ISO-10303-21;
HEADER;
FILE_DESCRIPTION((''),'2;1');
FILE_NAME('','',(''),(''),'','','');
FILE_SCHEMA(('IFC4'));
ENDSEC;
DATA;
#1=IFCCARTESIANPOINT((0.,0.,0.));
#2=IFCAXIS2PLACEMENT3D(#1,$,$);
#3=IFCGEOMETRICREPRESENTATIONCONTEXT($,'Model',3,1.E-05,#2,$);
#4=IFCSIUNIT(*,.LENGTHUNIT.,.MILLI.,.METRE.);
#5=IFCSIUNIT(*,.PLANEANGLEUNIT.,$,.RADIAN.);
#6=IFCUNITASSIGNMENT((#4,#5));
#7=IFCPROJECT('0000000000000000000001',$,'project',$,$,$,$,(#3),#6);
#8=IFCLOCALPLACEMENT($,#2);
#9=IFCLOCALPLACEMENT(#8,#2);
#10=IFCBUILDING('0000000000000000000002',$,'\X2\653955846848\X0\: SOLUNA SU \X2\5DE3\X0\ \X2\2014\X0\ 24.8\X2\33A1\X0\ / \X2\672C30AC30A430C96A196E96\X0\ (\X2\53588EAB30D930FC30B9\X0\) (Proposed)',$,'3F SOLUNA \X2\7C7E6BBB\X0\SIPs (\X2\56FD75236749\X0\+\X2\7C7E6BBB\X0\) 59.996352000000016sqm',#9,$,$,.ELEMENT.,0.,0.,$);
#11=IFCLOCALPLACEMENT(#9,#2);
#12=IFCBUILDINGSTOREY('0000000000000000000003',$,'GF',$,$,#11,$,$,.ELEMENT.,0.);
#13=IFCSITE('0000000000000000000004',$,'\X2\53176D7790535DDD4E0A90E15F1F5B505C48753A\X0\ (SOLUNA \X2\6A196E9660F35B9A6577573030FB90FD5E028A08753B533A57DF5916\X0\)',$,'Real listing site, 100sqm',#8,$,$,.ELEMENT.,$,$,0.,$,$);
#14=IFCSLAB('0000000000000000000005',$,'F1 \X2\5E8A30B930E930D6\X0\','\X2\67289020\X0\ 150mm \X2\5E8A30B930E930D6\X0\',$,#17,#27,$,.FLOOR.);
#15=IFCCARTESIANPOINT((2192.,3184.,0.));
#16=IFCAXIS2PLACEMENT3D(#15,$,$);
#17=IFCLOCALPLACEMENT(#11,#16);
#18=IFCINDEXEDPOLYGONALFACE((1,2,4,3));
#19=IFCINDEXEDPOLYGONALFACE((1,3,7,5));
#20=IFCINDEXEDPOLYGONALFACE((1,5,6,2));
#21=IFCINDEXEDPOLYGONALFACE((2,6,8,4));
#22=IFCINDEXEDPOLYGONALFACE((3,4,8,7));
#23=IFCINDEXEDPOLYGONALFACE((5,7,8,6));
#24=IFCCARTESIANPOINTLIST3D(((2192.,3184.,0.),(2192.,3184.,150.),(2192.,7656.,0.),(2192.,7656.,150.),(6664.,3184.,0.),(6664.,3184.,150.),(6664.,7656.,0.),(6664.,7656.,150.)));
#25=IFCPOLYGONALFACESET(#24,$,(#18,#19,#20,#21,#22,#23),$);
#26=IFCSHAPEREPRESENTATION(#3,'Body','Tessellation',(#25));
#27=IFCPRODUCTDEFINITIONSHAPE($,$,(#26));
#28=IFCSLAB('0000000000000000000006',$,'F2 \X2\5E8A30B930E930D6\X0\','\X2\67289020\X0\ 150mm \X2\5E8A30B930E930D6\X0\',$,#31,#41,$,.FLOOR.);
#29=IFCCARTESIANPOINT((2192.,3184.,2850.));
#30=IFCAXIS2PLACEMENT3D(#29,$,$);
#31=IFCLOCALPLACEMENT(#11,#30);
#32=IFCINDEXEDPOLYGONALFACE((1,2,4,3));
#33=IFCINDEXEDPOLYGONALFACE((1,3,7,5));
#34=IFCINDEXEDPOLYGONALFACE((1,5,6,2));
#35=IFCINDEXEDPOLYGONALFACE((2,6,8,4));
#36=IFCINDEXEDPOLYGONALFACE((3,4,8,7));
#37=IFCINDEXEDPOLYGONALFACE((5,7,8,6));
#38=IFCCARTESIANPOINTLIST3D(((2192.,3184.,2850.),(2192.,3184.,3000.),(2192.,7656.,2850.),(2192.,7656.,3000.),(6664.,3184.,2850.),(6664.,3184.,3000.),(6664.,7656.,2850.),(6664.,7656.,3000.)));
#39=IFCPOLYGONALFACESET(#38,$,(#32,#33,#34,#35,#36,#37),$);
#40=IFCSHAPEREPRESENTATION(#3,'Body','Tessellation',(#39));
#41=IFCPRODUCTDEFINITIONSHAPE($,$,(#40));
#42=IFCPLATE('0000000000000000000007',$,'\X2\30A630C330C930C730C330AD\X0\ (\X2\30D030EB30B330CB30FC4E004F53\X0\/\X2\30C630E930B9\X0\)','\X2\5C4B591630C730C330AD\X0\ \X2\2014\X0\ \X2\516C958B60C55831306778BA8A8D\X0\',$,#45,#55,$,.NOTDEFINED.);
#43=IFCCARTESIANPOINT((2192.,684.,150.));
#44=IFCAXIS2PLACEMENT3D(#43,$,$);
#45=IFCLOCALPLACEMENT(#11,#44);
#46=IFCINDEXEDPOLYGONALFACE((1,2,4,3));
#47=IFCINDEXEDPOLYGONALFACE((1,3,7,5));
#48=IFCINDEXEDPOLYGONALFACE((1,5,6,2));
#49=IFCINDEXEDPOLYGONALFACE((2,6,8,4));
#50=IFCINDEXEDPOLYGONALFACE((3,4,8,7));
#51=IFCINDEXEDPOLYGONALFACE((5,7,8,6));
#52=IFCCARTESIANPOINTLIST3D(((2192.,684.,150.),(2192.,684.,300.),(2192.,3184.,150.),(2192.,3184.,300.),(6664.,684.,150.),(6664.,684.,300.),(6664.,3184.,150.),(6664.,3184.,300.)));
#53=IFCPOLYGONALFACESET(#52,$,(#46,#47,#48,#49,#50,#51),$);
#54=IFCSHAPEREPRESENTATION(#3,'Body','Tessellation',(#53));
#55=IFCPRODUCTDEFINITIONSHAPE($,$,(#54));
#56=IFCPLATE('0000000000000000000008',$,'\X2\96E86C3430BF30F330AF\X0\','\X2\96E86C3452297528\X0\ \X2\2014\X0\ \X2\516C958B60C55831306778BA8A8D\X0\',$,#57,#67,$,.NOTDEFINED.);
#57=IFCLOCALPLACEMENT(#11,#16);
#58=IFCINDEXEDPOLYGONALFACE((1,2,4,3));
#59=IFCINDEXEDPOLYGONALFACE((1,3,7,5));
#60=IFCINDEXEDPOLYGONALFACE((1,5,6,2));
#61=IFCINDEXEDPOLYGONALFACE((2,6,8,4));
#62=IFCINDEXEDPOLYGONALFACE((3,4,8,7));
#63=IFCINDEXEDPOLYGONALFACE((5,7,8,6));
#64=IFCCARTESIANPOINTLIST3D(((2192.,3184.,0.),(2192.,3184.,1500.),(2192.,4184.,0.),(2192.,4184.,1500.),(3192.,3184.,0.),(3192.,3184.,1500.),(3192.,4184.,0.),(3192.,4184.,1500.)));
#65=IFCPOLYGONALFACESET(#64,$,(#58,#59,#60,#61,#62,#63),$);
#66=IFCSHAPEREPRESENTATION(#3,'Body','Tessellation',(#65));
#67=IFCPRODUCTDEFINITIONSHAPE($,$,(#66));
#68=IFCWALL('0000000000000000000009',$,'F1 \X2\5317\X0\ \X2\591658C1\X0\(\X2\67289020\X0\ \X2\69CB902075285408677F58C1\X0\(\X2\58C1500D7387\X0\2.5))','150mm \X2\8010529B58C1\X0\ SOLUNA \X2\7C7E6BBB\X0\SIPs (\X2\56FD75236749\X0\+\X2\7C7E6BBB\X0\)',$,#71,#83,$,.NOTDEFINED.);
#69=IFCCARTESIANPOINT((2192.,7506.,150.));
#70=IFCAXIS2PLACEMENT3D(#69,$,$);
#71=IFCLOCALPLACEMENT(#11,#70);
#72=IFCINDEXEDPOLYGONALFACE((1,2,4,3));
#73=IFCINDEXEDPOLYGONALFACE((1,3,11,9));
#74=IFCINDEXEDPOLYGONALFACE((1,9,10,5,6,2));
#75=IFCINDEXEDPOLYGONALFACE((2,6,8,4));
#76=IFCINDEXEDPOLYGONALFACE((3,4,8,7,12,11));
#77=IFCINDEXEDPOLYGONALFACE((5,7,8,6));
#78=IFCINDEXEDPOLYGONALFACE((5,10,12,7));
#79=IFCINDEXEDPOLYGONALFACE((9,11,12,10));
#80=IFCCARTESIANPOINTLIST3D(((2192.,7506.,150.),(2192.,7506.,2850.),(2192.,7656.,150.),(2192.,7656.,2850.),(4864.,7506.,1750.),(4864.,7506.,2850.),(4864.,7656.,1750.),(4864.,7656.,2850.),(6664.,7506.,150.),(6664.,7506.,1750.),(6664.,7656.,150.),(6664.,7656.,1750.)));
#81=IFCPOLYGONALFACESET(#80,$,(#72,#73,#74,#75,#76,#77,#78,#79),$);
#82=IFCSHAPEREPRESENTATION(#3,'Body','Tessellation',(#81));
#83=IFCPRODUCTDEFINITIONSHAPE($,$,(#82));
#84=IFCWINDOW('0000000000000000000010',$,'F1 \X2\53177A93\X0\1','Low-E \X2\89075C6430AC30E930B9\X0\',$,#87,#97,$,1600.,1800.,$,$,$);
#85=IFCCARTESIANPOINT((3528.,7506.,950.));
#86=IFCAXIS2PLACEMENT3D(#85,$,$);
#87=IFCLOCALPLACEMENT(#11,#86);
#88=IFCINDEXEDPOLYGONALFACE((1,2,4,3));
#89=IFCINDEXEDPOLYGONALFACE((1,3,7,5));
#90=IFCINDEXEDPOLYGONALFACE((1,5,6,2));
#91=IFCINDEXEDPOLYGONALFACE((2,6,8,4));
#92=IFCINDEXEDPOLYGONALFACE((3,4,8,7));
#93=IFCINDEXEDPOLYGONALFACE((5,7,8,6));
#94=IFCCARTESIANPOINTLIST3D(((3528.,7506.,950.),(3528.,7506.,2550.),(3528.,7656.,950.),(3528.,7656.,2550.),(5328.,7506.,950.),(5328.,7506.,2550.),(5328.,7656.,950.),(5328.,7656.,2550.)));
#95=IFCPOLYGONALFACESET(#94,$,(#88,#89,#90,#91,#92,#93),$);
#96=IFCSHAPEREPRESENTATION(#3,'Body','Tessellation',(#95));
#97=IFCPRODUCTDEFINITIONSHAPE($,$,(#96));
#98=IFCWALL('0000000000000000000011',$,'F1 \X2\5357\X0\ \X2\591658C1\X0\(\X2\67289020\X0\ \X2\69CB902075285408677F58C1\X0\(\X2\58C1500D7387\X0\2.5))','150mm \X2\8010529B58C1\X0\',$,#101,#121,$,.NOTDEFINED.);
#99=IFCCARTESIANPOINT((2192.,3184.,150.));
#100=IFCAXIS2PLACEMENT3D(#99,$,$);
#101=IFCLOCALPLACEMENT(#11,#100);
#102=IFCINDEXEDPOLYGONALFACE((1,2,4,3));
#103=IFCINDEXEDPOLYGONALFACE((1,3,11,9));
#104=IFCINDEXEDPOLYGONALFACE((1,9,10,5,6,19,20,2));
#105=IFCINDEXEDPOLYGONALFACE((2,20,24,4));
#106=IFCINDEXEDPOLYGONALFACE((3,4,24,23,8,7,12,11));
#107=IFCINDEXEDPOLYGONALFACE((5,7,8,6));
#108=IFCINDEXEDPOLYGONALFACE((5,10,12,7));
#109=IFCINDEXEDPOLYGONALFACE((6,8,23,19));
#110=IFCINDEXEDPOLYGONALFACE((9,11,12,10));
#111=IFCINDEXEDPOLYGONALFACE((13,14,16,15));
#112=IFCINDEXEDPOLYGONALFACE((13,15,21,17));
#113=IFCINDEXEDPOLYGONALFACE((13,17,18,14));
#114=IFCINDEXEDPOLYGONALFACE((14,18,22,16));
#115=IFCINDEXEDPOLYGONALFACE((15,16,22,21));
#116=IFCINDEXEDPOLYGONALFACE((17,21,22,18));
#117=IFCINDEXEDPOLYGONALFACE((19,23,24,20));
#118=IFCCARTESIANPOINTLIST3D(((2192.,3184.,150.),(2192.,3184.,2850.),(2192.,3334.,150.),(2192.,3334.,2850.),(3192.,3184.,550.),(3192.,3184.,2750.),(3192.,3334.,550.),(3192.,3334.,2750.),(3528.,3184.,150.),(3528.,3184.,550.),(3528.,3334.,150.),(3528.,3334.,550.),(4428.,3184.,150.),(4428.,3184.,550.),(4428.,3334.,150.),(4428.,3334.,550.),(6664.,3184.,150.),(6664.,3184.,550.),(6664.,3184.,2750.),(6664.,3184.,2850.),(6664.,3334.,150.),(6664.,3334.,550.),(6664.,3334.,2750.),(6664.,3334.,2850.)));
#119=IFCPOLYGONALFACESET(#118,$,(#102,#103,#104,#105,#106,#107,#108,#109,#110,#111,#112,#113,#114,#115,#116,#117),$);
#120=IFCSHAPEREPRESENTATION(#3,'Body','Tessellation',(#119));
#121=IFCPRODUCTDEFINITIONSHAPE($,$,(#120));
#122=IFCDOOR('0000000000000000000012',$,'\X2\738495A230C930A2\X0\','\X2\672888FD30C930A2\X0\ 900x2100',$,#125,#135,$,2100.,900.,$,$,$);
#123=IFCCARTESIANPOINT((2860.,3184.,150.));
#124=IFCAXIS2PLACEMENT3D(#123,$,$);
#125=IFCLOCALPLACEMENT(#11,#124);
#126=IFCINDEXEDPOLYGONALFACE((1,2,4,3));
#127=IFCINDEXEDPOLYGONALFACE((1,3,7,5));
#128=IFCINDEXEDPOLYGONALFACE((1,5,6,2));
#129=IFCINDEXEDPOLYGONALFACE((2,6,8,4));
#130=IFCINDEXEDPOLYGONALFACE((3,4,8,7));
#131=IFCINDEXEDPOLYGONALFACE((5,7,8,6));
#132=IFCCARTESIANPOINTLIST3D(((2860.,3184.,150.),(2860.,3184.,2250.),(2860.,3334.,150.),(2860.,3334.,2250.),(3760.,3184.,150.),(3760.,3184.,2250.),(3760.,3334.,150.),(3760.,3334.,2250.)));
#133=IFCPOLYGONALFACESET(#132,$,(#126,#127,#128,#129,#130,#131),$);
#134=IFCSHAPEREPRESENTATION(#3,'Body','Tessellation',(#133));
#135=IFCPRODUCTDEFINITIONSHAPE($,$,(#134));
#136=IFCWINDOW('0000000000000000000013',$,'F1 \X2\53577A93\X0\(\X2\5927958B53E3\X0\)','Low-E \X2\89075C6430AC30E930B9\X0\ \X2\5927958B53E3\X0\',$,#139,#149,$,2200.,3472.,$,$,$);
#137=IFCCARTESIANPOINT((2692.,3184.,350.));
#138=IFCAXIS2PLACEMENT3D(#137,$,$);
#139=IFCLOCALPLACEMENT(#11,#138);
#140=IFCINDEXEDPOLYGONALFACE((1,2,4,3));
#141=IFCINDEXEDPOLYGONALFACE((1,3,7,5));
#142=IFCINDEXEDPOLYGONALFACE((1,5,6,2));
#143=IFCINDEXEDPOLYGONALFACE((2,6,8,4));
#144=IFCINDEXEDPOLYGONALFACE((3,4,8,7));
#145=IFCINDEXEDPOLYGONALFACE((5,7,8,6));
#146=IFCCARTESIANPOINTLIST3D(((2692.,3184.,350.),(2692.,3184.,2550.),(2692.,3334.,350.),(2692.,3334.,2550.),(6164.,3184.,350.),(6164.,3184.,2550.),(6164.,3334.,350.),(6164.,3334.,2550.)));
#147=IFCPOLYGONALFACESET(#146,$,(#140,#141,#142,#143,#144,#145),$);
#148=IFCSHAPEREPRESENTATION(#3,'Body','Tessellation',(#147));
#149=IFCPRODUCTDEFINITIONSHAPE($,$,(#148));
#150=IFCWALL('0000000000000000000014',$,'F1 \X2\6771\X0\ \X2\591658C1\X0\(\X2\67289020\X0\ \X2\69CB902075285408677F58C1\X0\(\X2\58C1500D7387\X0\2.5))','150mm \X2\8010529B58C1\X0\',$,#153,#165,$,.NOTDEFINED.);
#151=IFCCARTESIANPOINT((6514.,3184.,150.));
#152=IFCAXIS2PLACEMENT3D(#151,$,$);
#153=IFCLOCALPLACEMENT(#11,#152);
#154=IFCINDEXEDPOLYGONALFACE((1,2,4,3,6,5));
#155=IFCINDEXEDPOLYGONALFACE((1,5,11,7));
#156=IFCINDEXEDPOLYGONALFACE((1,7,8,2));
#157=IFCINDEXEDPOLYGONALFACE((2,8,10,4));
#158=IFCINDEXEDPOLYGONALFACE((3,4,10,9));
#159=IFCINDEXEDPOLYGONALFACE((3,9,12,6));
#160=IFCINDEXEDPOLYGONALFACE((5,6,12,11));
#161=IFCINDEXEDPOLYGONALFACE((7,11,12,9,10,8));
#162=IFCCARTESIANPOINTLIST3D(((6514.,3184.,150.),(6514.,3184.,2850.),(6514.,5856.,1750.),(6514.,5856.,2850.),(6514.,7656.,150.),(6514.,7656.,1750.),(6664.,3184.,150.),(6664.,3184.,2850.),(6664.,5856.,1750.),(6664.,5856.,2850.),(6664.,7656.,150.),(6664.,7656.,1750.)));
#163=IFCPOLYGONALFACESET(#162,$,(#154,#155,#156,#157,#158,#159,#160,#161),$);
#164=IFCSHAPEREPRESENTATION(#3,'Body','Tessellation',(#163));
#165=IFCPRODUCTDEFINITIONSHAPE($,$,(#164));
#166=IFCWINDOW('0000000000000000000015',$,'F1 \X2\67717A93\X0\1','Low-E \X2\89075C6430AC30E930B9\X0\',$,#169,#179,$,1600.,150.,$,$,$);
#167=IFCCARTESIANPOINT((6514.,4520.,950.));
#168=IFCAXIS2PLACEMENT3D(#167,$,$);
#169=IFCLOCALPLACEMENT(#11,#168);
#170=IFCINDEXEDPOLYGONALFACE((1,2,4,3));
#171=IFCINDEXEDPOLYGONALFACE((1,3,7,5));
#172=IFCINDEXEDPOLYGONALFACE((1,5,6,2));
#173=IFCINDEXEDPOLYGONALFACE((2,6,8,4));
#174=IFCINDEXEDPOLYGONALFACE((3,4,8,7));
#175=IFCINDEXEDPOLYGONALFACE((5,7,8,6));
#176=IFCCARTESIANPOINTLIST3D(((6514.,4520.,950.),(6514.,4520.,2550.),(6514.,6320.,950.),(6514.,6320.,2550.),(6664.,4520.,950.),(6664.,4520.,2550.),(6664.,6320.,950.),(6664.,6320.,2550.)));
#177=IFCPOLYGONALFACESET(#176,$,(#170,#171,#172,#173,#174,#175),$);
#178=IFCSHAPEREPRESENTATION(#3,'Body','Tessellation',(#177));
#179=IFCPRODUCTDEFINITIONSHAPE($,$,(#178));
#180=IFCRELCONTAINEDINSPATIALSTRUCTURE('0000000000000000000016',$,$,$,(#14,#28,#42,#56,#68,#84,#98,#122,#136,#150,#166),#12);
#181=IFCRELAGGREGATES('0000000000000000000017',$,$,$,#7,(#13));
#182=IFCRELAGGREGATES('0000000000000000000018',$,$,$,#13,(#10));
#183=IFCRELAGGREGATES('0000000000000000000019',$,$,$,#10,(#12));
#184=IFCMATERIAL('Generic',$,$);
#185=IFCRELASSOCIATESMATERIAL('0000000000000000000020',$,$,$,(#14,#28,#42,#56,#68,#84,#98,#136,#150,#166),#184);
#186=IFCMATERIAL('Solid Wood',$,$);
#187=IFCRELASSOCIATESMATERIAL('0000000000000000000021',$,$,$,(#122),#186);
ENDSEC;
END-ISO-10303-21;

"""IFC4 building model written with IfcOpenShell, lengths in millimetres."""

from ifc_helpers import new_model, si_unit, frame, frame_2d, origin, place, context, project, spatial, rectangle, extrude, material, element, fill, save


model = new_model("IFC4")

# Units and contexts
model_context = context("Model", 3, precision=1e-05, world=origin())
ifc_project = project(units=[si_unit("LENGTHUNIT", "METRE", prefix="MILLI"), si_unit("PLANEANGLEUNIT", "RADIAN")], contexts=[model_context])

# Site, building, storey
site_placement = place(None, origin())
site = spatial("IfcSite", under=ifc_project, at=site_placement, Name="北海道川上郡弟子屈町 (SOLUNA 標準想定敷地・都市計画区域外)", ObjectType="Real listing site, 100sqm", CompositionType="ELEMENT", RefElevation=0.0)
building_placement = place(site_placement, origin())
building = spatial("IfcBuilding", under=site, at=building_placement, Name="改善案: SOLUNA SU 巣 — 24.8㎡ / 本ガイド標準 (単身ベース) (Proposed)", ObjectType="3F SOLUNA 籾殻SIPs (国産杉+籾殻) 59.996352000000016sqm", CompositionType="ELEMENT", ElevationOfRefHeight=0.0, ElevationOfTerrain=0.0)
storey_placement = place(building_placement, origin())
storey = spatial("IfcBuildingStorey", under=building, at=storey_placement, Name="GF", CompositionType="ELEMENT", Elevation=0.0)

# Slabs
ifc_material_1 = material(Name="Generic")
slab_1_placement = place(storey_placement, frame((2192.0, 3184.0, 0.0)))
element("IfcSlab", 1, at=slab_1_placement, inside=storey, material=ifc_material_1, Name="F1 床スラブ", Description="木造 150mm 床スラブ", PredefinedType="FLOOR", context=model_context, shape_type="SweptSolid", body=[
    extrude(rectangle(XDim=4472.0, YDim=4472.0, at=frame_2d((2236.0, 2236.0))), frame((2192.0, 3184.0, 0.0)), (0.0, 0.0, 1.0), 150.0),
])
slab_2_placement = place(storey_placement, frame((2192.0, 3184.0, 2850.0)))
element("IfcSlab", 2, at=slab_2_placement, inside=storey, material=ifc_material_1, Name="F2 床スラブ", Description="木造 150mm 床スラブ", PredefinedType="FLOOR", context=model_context, shape_type="SweptSolid", body=[
    extrude(rectangle(XDim=4472.0, YDim=4472.0, at=frame_2d((2236.0, 2236.0))), frame((2192.0, 3184.0, 2850.0)), (0.0, 0.0, 1.0), 150.0),
])

# Plates
plate_1_placement = place(storey_placement, frame((2192.0, 684.0, 150.0)))
element("IfcPlate", 3, at=plate_1_placement, inside=storey, material=ifc_material_1, Name="ウッドデッキ (バルコニー一体/テラス)", Description="屋外デッキ — 公開情報で確認", PredefinedType="NOTDEFINED", context=model_context, shape_type="SweptSolid", body=[
    extrude(rectangle(XDim=4472.0, YDim=2500.0, at=frame_2d((2236.0, 1250.0))), frame((2192.0, 684.0, 150.0)), (0.0, 0.0, 1.0), 150.0),
])
plate_2_placement = place(storey_placement, frame((2192.0, 3184.0, 0.0)))
element("IfcPlate", 4, at=plate_2_placement, inside=storey, material=ifc_material_1, Name="雨水タンク", Description="雨水利用 — 公開情報で確認", PredefinedType="NOTDEFINED", context=model_context, shape_type="SweptSolid", body=[
    extrude(rectangle(XDim=1000.0, YDim=1000.0, at=frame_2d((500.0, 500.0))), frame((2192.0, 3184.0, 0.0)), (0.0, 0.0, 1.0), 1500.0),
])

# Wall, opening, window
wall_1_placement = place(storey_placement, frame((2192.0, 7506.0, 150.0)))
wall_1 = element("IfcWall", 5, at=wall_1_placement, inside=storey, material=ifc_material_1, Name="F1 北 外壁(木造 構造用合板壁(壁倍率2.5))", Description="150mm 耐力壁 SOLUNA 籾殻SIPs (国産杉+籾殻)", PredefinedType="NOTDEFINED", context=model_context, shape_type="SweptSolid", body=[
    extrude(rectangle(XDim=4472.0, YDim=150.0, at=frame_2d((2236.0, 75.0))), frame((2192.0, 7506.0, 150.0)), (0.0, 0.0, 1.0), 2700.0),
])
opening_1_placement = place(storey_placement, frame((3528.0, 7506.0, 950.0)))
opening_1 = element("IfcOpeningElement", 6, at=opening_1_placement, cuts=wall_1, PredefinedType="NOTDEFINED", context=model_context, shape_type="SweptSolid", body=[
    extrude(rectangle(XDim=1800.0, YDim=150.0, at=frame_2d((900.0, 75.0))), frame((3528.0, 7506.0, 950.0)), (0.0, 0.0, 1.0), 1600.0),
])
window_1_placement = place(storey_placement, frame((3528.0, 7506.0, 950.0)))
window_1 = element("IfcWindow", 7, at=window_1_placement, inside=storey, material=ifc_material_1, Name="F1 北窓1", Description="Low-E 複層ガラス", OverallHeight=1600.0, OverallWidth=1800.0, context=model_context, shape_type="SweptSolid", body=[
    extrude(rectangle(XDim=1800.0, YDim=150.0, at=frame_2d((900.0, 75.0))), frame((3528.0, 7506.0, 950.0)), (0.0, 0.0, 1.0), 1600.0),
])
fill(opening_1, window_1)

# Wall, openings, door, window
wall_2_placement = place(storey_placement, frame((2192.0, 3184.0, 150.0)))
wall_2 = element("IfcWall", 8, at=wall_2_placement, inside=storey, material=ifc_material_1, Name="F1 南 外壁(木造 構造用合板壁(壁倍率2.5))", Description="150mm 耐力壁", PredefinedType="NOTDEFINED", context=model_context, shape_type="SweptSolid", body=[
    extrude(rectangle(XDim=4472.0, YDim=150.0, at=frame_2d((2236.0, 75.0))), frame((2192.0, 3184.0, 150.0)), (0.0, 0.0, 1.0), 2700.0),
])
opening_2_placement = place(storey_placement, frame((2860.0, 3184.0, 150.0)))
opening_2 = element("IfcOpeningElement", 9, at=opening_2_placement, cuts=wall_2, PredefinedType="NOTDEFINED", context=model_context, shape_type="SweptSolid", body=[
    extrude(rectangle(XDim=900.0, YDim=150.0, at=frame_2d((450.0, 75.0))), frame((2860.0, 3184.0, 150.0)), (0.0, 0.0, 1.0), 2100.0),
])
opening_3_placement = place(storey_placement, frame((2692.0, 3184.0, 350.0)))
opening_3 = element("IfcOpeningElement", 10, at=opening_3_placement, cuts=wall_2, PredefinedType="NOTDEFINED", context=model_context, shape_type="SweptSolid", body=[
    extrude(rectangle(XDim=3472.0, YDim=150.0, at=frame_2d((1736.0, 75.0))), frame((2692.0, 3184.0, 350.0)), (0.0, 0.0, 1.0), 2200.0),
])
ifc_material_2 = material(Name="Solid Wood")
door_placement = place(storey_placement, frame((2860.0, 3184.0, 150.0)))
door = element("IfcDoor", 11, at=door_placement, inside=storey, material=ifc_material_2, Name="玄関ドア", Description="木製ドア 900x2100", OverallHeight=2100.0, OverallWidth=900.0, context=model_context, shape_type="SweptSolid", body=[
    extrude(rectangle(XDim=900.0, YDim=150.0, at=frame_2d((450.0, 75.0))), frame((2860.0, 3184.0, 150.0)), (0.0, 0.0, 1.0), 2100.0),
])
fill(opening_2, door)
window_2_placement = place(storey_placement, frame((2692.0, 3184.0, 350.0)))
window_2 = element("IfcWindow", 12, at=window_2_placement, inside=storey, material=ifc_material_1, Name="F1 南窓(大開口)", Description="Low-E 複層ガラス 大開口", OverallHeight=2200.0, OverallWidth=3472.0, context=model_context, shape_type="SweptSolid", body=[
    extrude(rectangle(XDim=3472.0, YDim=150.0, at=frame_2d((1736.0, 75.0))), frame((2692.0, 3184.0, 350.0)), (0.0, 0.0, 1.0), 2200.0),
])
fill(opening_3, window_2)

# Wall, opening, window
wall_3_placement = place(storey_placement, frame((6514.0, 3184.0, 150.0)))
wall_3 = element("IfcWall", 13, at=wall_3_placement, inside=storey, material=ifc_material_1, Name="F1 東 外壁(木造 構造用合板壁(壁倍率2.5))", Description="150mm 耐力壁", PredefinedType="NOTDEFINED", context=model_context, shape_type="SweptSolid", body=[
    extrude(rectangle(XDim=150.0, YDim=4472.0, at=frame_2d((75.0, 2236.0))), frame((6514.0, 3184.0, 150.0)), (0.0, 0.0, 1.0), 2700.0),
])
opening_4_placement = place(storey_placement, frame((6514.0, 4520.0, 950.0)))
opening_4 = element("IfcOpeningElement", 14, at=opening_4_placement, cuts=wall_3, PredefinedType="NOTDEFINED", context=model_context, shape_type="SweptSolid", body=[
    extrude(rectangle(XDim=150.0, YDim=1800.0, at=frame_2d((75.0, 900.0))), frame((6514.0, 4520.0, 950.0)), (0.0, 0.0, 1.0), 1600.0),
])
window_3_placement = place(storey_placement, frame((6514.0, 4520.0, 950.0)))
window_3 = element("IfcWindow", 15, at=window_3_placement, inside=storey, material=ifc_material_1, Name="F1 東窓1", Description="Low-E 複層ガラス", OverallHeight=1600.0, OverallWidth=150.0, context=model_context, shape_type="SweptSolid", body=[
    extrude(rectangle(XDim=150.0, YDim=1800.0, at=frame_2d((75.0, 900.0))), frame((6514.0, 4520.0, 950.0)), (0.0, 0.0, 1.0), 1600.0),
])
fill(opening_4, window_3)

save(model, "model.ifc")
